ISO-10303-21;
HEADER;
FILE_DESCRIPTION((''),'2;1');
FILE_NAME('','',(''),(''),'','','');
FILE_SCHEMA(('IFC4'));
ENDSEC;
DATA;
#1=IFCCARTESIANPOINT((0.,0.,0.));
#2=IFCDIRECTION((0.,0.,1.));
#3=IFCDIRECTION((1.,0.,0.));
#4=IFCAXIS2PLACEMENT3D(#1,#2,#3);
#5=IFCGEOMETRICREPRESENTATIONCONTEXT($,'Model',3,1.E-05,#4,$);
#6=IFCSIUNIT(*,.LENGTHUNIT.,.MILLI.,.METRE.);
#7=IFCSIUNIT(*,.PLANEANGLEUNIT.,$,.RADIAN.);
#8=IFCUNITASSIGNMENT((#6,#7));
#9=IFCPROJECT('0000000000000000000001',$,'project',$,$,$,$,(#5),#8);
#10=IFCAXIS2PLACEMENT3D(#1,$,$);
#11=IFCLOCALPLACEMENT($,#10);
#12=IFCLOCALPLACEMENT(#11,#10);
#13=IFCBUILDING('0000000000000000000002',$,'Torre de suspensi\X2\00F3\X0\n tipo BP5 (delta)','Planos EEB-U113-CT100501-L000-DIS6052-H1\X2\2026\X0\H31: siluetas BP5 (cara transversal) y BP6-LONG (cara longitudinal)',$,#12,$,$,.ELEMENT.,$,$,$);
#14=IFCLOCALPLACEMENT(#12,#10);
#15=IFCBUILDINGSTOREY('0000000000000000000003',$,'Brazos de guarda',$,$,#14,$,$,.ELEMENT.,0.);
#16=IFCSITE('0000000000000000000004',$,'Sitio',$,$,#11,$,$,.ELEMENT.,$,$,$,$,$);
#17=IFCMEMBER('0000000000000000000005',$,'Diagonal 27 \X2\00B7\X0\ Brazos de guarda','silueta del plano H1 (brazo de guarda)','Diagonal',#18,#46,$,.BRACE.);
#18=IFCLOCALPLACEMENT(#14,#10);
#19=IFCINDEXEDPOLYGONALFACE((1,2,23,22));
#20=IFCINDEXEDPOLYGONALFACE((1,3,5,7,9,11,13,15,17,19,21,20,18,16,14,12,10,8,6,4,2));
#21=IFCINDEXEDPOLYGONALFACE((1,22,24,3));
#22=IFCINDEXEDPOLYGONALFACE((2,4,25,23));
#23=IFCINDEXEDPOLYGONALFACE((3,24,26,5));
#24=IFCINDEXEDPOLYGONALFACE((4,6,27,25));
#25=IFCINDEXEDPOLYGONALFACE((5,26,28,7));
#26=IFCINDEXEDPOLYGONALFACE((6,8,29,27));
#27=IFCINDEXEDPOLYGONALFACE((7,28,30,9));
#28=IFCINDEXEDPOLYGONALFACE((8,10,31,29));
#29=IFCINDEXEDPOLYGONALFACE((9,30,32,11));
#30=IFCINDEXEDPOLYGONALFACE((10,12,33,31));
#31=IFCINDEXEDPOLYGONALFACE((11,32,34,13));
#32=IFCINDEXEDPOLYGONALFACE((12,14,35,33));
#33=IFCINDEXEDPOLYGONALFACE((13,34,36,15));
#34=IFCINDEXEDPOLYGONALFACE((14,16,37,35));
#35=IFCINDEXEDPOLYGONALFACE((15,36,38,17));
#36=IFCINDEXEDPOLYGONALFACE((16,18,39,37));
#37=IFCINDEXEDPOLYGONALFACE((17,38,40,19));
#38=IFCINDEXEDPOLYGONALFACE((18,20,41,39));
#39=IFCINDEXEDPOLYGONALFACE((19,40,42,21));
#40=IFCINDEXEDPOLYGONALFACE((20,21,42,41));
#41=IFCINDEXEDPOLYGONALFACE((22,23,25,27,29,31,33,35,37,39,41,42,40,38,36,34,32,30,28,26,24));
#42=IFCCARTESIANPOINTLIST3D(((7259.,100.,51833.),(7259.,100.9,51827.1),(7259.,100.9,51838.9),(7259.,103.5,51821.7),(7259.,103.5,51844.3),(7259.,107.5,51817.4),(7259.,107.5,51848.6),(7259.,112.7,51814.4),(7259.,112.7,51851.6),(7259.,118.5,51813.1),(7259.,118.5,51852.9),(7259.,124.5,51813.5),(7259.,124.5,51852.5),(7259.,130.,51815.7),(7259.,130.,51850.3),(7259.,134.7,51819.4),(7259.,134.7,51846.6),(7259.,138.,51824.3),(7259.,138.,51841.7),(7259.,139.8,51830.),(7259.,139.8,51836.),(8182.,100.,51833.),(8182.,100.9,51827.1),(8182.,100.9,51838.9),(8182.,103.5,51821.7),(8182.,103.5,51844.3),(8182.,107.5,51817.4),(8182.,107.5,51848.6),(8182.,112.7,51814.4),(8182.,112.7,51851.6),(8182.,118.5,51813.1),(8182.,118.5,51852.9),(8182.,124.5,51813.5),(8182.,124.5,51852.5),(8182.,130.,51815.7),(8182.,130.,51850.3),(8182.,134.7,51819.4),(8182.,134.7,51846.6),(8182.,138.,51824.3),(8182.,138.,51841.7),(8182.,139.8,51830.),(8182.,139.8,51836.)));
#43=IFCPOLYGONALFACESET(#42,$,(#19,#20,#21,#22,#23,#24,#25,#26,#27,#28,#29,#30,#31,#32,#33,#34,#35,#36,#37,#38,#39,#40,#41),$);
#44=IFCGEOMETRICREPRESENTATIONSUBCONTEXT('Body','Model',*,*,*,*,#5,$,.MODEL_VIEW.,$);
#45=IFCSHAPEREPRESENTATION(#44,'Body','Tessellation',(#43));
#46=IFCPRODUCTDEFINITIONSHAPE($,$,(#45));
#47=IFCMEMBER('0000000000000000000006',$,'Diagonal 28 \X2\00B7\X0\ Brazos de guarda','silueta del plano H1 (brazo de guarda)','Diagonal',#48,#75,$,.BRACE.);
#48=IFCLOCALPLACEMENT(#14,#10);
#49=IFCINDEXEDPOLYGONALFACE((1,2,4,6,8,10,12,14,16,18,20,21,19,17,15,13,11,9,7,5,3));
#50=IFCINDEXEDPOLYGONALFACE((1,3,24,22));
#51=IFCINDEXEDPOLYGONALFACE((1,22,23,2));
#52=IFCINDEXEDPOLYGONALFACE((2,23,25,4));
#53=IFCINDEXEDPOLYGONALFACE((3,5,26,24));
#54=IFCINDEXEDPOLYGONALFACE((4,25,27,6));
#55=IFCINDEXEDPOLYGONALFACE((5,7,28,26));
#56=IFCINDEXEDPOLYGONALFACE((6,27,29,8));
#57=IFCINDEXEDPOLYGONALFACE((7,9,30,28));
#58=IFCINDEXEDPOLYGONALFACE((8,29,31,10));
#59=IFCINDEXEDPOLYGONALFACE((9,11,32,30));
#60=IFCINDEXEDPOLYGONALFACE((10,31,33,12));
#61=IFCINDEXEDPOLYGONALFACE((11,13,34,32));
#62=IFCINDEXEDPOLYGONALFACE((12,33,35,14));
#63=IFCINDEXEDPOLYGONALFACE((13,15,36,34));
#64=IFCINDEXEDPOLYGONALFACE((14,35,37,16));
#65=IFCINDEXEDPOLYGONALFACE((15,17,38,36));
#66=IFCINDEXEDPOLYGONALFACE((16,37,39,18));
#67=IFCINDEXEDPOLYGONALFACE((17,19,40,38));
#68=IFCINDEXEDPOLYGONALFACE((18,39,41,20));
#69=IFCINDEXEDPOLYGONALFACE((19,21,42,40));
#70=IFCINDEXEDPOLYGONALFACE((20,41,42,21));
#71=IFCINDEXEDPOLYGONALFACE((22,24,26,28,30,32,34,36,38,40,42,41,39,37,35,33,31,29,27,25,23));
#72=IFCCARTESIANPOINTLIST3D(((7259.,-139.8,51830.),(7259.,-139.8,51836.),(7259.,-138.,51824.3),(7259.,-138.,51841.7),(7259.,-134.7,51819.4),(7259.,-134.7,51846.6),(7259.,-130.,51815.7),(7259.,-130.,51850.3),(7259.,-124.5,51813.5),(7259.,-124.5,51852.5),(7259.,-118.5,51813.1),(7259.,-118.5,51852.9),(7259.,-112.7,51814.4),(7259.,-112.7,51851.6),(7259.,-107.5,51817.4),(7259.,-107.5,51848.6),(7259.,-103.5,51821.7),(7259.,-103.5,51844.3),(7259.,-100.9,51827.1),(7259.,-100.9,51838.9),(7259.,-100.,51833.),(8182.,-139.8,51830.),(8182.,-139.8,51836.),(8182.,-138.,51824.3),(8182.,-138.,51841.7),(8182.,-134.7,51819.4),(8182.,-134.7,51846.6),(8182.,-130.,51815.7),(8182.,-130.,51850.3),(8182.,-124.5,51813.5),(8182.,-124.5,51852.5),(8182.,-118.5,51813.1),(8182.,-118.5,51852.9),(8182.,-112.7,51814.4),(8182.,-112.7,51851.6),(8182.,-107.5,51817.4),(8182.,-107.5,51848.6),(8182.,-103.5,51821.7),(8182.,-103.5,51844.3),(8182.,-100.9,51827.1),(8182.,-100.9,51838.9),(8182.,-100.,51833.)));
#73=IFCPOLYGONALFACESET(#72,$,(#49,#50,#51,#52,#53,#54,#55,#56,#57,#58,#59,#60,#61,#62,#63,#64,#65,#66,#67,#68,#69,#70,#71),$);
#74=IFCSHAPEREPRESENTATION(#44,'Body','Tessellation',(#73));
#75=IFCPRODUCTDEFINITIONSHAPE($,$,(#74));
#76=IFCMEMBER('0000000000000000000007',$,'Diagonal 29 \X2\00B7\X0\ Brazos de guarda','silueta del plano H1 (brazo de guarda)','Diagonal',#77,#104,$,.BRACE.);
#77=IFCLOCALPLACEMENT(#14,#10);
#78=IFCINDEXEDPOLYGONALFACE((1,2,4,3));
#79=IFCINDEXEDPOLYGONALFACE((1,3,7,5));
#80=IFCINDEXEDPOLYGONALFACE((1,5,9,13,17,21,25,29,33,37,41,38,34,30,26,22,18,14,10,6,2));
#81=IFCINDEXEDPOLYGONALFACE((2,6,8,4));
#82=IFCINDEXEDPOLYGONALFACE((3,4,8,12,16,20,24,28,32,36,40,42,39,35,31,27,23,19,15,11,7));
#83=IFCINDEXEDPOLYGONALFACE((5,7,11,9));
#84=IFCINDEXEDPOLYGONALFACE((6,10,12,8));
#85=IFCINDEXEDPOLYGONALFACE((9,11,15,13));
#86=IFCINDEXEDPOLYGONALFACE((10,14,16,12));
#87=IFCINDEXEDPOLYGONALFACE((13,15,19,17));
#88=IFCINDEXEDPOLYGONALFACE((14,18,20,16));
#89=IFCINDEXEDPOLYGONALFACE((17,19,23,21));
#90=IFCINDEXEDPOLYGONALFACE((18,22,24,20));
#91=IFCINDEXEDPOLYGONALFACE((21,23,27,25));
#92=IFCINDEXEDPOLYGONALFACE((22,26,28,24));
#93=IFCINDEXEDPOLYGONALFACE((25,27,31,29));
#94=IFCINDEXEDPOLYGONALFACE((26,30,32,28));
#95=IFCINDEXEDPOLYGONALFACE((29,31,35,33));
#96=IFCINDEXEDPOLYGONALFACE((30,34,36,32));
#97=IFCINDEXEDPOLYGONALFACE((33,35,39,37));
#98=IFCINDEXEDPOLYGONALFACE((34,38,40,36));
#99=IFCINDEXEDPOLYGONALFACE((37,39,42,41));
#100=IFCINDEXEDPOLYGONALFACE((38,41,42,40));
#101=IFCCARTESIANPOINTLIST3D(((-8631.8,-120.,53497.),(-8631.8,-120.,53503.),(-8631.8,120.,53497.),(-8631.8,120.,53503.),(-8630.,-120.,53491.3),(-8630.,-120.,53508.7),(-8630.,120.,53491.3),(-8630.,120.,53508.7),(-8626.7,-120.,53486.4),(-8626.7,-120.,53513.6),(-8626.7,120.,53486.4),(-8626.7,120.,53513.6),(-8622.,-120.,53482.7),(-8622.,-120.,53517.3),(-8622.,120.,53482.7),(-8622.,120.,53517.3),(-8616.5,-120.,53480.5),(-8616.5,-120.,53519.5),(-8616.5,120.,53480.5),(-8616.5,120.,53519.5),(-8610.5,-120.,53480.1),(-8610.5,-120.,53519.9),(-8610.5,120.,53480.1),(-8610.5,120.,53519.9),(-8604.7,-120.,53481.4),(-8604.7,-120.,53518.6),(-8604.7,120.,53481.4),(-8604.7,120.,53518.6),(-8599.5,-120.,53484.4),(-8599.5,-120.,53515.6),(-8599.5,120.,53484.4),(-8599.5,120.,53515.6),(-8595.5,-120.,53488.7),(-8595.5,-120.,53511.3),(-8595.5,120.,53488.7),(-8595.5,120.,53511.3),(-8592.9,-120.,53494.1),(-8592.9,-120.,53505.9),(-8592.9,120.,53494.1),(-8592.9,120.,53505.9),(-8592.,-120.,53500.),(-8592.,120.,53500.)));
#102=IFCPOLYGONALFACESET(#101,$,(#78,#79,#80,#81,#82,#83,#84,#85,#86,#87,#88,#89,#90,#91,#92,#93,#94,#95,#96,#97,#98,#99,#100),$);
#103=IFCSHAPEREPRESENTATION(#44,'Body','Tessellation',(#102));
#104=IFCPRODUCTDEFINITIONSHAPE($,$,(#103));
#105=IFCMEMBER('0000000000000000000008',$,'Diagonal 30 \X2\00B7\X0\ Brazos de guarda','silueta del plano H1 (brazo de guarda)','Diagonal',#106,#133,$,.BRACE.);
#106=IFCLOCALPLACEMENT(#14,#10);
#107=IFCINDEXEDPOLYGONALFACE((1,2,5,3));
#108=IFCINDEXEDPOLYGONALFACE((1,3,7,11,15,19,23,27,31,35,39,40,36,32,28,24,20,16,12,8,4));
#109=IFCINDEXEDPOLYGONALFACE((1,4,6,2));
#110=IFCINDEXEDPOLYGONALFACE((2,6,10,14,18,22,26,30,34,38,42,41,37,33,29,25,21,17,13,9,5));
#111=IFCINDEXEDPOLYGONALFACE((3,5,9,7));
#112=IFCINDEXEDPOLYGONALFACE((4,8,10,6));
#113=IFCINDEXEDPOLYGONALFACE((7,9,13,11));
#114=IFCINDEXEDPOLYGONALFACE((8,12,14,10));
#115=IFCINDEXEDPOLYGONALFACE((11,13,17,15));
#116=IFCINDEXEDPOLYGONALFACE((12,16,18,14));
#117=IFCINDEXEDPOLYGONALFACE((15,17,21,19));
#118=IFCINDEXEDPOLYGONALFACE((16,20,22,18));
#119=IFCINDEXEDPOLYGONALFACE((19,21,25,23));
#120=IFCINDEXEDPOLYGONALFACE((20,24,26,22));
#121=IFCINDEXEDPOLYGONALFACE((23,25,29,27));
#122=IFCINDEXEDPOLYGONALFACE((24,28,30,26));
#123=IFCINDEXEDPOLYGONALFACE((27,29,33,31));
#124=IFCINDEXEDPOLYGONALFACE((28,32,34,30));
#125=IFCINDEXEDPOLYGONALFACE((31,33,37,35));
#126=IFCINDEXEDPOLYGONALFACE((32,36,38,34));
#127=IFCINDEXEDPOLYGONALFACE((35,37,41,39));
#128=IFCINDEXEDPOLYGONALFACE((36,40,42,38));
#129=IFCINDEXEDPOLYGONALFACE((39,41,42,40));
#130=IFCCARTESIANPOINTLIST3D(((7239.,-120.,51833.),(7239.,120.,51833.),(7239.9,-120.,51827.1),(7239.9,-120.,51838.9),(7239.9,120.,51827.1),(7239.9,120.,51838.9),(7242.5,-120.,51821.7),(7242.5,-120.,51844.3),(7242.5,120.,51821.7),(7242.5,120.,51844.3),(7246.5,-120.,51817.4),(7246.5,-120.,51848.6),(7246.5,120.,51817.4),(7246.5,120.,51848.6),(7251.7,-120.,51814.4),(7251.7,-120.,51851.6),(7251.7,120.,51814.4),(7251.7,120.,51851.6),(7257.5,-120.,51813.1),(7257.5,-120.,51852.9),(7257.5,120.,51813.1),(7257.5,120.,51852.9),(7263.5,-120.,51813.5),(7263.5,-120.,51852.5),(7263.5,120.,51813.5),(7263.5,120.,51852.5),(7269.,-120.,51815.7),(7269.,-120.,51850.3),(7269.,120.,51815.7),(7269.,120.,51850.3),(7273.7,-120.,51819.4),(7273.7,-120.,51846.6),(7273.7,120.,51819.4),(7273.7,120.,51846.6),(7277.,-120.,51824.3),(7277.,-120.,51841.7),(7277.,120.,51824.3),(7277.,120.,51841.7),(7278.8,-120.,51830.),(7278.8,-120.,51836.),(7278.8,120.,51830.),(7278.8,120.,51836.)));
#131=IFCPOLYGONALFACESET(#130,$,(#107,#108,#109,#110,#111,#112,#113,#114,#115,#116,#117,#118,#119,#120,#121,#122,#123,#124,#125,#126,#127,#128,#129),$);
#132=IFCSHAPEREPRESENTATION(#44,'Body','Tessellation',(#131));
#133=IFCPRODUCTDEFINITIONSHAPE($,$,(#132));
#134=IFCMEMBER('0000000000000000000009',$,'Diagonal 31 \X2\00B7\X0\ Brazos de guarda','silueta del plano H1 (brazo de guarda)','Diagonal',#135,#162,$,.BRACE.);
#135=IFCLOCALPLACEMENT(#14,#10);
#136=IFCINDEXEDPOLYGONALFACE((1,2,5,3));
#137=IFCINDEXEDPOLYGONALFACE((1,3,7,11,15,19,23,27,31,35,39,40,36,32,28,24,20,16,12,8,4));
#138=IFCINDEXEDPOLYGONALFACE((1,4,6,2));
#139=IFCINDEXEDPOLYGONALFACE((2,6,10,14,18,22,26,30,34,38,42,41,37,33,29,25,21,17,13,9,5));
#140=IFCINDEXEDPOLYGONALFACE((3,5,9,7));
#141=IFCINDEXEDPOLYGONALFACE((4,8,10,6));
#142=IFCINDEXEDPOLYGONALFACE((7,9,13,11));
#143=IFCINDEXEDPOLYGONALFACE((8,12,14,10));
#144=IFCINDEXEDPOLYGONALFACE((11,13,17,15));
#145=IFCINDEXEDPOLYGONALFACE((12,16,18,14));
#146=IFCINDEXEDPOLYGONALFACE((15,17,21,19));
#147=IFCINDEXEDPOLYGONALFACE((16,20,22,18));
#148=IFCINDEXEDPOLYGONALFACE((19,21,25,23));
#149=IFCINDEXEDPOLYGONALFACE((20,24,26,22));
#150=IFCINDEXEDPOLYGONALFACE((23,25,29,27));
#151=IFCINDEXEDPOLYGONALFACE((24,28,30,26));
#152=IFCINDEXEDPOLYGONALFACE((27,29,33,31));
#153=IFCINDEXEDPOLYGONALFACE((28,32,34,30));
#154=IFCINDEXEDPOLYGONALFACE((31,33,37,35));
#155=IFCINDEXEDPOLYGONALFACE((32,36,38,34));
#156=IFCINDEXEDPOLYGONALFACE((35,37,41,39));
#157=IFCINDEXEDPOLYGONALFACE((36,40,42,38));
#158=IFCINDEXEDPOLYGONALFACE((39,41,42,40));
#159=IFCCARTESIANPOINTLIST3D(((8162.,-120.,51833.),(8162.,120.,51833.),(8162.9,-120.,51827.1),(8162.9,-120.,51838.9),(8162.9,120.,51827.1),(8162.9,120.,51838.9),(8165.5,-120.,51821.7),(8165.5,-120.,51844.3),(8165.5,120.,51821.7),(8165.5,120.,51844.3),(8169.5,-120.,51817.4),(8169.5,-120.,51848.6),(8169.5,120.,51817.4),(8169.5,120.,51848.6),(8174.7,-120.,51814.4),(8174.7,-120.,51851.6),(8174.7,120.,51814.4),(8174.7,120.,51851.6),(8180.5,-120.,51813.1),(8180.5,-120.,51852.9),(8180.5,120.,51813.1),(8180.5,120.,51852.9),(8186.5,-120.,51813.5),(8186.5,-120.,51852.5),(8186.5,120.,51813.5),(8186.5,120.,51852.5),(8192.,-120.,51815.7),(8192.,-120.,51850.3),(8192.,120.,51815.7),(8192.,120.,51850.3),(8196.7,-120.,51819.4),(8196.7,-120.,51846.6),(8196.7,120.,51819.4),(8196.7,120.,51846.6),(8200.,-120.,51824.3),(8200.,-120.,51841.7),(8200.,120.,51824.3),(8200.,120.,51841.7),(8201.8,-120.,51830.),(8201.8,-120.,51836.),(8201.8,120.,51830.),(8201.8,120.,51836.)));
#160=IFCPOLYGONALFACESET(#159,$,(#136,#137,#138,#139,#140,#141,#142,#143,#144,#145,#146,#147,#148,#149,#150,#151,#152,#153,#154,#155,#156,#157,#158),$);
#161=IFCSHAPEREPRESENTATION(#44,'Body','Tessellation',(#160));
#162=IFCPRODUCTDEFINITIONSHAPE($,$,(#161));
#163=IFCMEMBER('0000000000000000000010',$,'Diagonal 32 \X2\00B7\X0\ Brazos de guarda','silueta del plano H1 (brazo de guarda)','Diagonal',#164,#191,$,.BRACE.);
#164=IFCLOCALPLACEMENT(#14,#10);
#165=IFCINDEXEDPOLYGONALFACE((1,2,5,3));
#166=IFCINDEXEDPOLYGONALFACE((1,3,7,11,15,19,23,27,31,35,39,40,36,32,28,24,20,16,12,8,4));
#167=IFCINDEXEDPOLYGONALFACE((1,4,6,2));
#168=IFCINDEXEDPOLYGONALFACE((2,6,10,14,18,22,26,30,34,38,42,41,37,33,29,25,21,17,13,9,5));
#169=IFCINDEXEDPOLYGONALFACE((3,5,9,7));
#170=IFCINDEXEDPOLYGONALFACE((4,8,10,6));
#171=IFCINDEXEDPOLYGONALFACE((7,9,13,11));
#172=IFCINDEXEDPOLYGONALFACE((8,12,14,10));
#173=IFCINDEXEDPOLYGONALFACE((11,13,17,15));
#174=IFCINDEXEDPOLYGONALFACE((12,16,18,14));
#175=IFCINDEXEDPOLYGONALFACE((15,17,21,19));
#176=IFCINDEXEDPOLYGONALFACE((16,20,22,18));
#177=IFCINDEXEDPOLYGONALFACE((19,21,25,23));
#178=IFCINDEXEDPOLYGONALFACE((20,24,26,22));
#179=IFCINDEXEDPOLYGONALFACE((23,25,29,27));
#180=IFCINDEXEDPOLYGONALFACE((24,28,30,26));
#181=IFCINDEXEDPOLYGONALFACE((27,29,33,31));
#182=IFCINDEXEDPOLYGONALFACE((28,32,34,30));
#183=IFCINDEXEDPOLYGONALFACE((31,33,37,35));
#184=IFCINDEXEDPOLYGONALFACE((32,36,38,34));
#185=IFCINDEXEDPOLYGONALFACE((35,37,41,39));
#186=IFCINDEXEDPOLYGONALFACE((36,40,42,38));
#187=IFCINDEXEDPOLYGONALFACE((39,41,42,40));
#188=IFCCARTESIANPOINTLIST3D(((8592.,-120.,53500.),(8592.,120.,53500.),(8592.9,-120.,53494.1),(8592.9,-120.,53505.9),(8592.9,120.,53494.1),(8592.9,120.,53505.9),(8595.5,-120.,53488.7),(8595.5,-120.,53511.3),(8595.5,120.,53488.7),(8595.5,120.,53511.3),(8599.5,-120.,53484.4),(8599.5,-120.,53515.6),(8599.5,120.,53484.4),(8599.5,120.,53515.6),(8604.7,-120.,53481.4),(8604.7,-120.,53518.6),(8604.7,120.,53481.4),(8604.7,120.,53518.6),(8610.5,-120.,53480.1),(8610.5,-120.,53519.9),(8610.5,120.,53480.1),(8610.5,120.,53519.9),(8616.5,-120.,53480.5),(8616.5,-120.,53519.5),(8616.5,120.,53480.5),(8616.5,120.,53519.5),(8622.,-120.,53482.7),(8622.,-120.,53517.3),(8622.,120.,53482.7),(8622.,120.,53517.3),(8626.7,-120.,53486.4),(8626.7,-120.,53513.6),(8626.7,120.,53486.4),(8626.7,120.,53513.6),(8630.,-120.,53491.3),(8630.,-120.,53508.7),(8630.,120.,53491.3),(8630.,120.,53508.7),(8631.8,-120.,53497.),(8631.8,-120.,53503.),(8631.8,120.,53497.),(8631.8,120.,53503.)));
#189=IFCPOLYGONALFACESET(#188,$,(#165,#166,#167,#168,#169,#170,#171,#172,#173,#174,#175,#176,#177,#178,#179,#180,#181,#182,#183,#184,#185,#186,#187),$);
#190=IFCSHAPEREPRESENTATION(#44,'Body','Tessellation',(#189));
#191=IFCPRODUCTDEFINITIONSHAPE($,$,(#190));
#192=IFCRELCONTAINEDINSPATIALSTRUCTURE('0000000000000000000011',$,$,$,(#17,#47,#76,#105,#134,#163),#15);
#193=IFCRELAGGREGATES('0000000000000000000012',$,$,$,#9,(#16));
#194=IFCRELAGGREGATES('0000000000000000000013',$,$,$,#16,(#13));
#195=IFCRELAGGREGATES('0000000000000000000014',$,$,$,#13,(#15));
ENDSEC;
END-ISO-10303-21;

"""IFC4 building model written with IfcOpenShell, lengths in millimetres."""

from ifc_helpers import new_model, si_unit, frame, origin, origin_with_axes, place, context, subcontext, project, spatial, circle, extrude, element, save


model = new_model("IFC4")

# Units and contexts
model_context = context("Model", 3, precision=1e-05, world=origin_with_axes())
body_context = subcontext(model_context, "Body", "Model", "MODEL_VIEW")
ifc_project = project(units=[si_unit("LENGTHUNIT", "METRE", prefix="MILLI"), si_unit("PLANEANGLEUNIT", "RADIAN")], contexts=[model_context])

# Site, building, storey
site_placement = place(None, origin())
site = spatial("IfcSite", under=ifc_project, at=site_placement, Name="Sitio", CompositionType="ELEMENT")
building_placement = place(site_placement, origin())
building = spatial("IfcBuilding", under=site, at=building_placement, Name="Torre de suspensión tipo BP5 (delta)", Description="Planos EEB-U113-CT100501-L000-DIS6052-H1…H31: siluetas BP5 (cara transversal) y BP6-LONG (cara longitudinal)", CompositionType="ELEMENT")
storey_placement = place(building_placement, origin())
storey = spatial("IfcBuildingStorey", under=building, at=storey_placement, Name="Brazos de guarda", CompositionType="ELEMENT", Elevation=0.0)

# Members
for number, where, z_axis, x_axis, name in (
    (1, (7259.0, 120.0, 51833.0), (1.0, 0.0, 0.0), (0.0, -1.0, 0.0), "Diagonal 27 · Brazos de guarda"),
    (2, (7259.0, -120.0, 51833.0), (1.0, 0.0, 0.0), (0.0, 1.0, 0.0), "Diagonal 28 · Brazos de guarda"),
):
    element("IfcMember", number, at=place(storey_placement, frame(where, z_axis=z_axis, x_axis=x_axis)), inside=storey, Name=name, Description="silueta del plano H1 (brazo de guarda)", ObjectType="Diagonal", PredefinedType="BRACE", context=body_context, shape_type="SweptSolid", body=[
        extrude(circle(Radius=20.0), None, (0.0, 0.0, 1.0), 923.0),
    ])
for number, where, z_axis, x_axis, name in (
    (3, (-8612.0, 120.0, 53500.0), (0.0, -1.0, 0.0), (1.0, 0.0, 0.0), "Diagonal 29 · Brazos de guarda"),
    (4, (7259.0, 120.0, 51833.0), (0.0, -1.0, 0.0), (-1.0, 0.0, 0.0), "Diagonal 30 · Brazos de guarda"),
    (5, (8182.0, 120.0, 51833.0), (0.0, -1.0, 0.0), (-1.0, 0.0, 0.0), "Diagonal 31 · Brazos de guarda"),
    (6, (8612.0, 120.0, 53500.0), (0.0, -1.0, 0.0), (-1.0, 0.0, 0.0), "Diagonal 32 · Brazos de guarda"),
):
    element("IfcMember", number, at=place(storey_placement, frame(where, z_axis=z_axis, x_axis=x_axis)), inside=storey, Name=name, Description="silueta del plano H1 (brazo de guarda)", ObjectType="Diagonal", PredefinedType="BRACE", context=body_context, shape_type="SweptSolid", body=[
        extrude(circle(Radius=20.0), None, (0.0, 0.0, 1.0), 240.0),
    ])

save(model, "model.ifc")
